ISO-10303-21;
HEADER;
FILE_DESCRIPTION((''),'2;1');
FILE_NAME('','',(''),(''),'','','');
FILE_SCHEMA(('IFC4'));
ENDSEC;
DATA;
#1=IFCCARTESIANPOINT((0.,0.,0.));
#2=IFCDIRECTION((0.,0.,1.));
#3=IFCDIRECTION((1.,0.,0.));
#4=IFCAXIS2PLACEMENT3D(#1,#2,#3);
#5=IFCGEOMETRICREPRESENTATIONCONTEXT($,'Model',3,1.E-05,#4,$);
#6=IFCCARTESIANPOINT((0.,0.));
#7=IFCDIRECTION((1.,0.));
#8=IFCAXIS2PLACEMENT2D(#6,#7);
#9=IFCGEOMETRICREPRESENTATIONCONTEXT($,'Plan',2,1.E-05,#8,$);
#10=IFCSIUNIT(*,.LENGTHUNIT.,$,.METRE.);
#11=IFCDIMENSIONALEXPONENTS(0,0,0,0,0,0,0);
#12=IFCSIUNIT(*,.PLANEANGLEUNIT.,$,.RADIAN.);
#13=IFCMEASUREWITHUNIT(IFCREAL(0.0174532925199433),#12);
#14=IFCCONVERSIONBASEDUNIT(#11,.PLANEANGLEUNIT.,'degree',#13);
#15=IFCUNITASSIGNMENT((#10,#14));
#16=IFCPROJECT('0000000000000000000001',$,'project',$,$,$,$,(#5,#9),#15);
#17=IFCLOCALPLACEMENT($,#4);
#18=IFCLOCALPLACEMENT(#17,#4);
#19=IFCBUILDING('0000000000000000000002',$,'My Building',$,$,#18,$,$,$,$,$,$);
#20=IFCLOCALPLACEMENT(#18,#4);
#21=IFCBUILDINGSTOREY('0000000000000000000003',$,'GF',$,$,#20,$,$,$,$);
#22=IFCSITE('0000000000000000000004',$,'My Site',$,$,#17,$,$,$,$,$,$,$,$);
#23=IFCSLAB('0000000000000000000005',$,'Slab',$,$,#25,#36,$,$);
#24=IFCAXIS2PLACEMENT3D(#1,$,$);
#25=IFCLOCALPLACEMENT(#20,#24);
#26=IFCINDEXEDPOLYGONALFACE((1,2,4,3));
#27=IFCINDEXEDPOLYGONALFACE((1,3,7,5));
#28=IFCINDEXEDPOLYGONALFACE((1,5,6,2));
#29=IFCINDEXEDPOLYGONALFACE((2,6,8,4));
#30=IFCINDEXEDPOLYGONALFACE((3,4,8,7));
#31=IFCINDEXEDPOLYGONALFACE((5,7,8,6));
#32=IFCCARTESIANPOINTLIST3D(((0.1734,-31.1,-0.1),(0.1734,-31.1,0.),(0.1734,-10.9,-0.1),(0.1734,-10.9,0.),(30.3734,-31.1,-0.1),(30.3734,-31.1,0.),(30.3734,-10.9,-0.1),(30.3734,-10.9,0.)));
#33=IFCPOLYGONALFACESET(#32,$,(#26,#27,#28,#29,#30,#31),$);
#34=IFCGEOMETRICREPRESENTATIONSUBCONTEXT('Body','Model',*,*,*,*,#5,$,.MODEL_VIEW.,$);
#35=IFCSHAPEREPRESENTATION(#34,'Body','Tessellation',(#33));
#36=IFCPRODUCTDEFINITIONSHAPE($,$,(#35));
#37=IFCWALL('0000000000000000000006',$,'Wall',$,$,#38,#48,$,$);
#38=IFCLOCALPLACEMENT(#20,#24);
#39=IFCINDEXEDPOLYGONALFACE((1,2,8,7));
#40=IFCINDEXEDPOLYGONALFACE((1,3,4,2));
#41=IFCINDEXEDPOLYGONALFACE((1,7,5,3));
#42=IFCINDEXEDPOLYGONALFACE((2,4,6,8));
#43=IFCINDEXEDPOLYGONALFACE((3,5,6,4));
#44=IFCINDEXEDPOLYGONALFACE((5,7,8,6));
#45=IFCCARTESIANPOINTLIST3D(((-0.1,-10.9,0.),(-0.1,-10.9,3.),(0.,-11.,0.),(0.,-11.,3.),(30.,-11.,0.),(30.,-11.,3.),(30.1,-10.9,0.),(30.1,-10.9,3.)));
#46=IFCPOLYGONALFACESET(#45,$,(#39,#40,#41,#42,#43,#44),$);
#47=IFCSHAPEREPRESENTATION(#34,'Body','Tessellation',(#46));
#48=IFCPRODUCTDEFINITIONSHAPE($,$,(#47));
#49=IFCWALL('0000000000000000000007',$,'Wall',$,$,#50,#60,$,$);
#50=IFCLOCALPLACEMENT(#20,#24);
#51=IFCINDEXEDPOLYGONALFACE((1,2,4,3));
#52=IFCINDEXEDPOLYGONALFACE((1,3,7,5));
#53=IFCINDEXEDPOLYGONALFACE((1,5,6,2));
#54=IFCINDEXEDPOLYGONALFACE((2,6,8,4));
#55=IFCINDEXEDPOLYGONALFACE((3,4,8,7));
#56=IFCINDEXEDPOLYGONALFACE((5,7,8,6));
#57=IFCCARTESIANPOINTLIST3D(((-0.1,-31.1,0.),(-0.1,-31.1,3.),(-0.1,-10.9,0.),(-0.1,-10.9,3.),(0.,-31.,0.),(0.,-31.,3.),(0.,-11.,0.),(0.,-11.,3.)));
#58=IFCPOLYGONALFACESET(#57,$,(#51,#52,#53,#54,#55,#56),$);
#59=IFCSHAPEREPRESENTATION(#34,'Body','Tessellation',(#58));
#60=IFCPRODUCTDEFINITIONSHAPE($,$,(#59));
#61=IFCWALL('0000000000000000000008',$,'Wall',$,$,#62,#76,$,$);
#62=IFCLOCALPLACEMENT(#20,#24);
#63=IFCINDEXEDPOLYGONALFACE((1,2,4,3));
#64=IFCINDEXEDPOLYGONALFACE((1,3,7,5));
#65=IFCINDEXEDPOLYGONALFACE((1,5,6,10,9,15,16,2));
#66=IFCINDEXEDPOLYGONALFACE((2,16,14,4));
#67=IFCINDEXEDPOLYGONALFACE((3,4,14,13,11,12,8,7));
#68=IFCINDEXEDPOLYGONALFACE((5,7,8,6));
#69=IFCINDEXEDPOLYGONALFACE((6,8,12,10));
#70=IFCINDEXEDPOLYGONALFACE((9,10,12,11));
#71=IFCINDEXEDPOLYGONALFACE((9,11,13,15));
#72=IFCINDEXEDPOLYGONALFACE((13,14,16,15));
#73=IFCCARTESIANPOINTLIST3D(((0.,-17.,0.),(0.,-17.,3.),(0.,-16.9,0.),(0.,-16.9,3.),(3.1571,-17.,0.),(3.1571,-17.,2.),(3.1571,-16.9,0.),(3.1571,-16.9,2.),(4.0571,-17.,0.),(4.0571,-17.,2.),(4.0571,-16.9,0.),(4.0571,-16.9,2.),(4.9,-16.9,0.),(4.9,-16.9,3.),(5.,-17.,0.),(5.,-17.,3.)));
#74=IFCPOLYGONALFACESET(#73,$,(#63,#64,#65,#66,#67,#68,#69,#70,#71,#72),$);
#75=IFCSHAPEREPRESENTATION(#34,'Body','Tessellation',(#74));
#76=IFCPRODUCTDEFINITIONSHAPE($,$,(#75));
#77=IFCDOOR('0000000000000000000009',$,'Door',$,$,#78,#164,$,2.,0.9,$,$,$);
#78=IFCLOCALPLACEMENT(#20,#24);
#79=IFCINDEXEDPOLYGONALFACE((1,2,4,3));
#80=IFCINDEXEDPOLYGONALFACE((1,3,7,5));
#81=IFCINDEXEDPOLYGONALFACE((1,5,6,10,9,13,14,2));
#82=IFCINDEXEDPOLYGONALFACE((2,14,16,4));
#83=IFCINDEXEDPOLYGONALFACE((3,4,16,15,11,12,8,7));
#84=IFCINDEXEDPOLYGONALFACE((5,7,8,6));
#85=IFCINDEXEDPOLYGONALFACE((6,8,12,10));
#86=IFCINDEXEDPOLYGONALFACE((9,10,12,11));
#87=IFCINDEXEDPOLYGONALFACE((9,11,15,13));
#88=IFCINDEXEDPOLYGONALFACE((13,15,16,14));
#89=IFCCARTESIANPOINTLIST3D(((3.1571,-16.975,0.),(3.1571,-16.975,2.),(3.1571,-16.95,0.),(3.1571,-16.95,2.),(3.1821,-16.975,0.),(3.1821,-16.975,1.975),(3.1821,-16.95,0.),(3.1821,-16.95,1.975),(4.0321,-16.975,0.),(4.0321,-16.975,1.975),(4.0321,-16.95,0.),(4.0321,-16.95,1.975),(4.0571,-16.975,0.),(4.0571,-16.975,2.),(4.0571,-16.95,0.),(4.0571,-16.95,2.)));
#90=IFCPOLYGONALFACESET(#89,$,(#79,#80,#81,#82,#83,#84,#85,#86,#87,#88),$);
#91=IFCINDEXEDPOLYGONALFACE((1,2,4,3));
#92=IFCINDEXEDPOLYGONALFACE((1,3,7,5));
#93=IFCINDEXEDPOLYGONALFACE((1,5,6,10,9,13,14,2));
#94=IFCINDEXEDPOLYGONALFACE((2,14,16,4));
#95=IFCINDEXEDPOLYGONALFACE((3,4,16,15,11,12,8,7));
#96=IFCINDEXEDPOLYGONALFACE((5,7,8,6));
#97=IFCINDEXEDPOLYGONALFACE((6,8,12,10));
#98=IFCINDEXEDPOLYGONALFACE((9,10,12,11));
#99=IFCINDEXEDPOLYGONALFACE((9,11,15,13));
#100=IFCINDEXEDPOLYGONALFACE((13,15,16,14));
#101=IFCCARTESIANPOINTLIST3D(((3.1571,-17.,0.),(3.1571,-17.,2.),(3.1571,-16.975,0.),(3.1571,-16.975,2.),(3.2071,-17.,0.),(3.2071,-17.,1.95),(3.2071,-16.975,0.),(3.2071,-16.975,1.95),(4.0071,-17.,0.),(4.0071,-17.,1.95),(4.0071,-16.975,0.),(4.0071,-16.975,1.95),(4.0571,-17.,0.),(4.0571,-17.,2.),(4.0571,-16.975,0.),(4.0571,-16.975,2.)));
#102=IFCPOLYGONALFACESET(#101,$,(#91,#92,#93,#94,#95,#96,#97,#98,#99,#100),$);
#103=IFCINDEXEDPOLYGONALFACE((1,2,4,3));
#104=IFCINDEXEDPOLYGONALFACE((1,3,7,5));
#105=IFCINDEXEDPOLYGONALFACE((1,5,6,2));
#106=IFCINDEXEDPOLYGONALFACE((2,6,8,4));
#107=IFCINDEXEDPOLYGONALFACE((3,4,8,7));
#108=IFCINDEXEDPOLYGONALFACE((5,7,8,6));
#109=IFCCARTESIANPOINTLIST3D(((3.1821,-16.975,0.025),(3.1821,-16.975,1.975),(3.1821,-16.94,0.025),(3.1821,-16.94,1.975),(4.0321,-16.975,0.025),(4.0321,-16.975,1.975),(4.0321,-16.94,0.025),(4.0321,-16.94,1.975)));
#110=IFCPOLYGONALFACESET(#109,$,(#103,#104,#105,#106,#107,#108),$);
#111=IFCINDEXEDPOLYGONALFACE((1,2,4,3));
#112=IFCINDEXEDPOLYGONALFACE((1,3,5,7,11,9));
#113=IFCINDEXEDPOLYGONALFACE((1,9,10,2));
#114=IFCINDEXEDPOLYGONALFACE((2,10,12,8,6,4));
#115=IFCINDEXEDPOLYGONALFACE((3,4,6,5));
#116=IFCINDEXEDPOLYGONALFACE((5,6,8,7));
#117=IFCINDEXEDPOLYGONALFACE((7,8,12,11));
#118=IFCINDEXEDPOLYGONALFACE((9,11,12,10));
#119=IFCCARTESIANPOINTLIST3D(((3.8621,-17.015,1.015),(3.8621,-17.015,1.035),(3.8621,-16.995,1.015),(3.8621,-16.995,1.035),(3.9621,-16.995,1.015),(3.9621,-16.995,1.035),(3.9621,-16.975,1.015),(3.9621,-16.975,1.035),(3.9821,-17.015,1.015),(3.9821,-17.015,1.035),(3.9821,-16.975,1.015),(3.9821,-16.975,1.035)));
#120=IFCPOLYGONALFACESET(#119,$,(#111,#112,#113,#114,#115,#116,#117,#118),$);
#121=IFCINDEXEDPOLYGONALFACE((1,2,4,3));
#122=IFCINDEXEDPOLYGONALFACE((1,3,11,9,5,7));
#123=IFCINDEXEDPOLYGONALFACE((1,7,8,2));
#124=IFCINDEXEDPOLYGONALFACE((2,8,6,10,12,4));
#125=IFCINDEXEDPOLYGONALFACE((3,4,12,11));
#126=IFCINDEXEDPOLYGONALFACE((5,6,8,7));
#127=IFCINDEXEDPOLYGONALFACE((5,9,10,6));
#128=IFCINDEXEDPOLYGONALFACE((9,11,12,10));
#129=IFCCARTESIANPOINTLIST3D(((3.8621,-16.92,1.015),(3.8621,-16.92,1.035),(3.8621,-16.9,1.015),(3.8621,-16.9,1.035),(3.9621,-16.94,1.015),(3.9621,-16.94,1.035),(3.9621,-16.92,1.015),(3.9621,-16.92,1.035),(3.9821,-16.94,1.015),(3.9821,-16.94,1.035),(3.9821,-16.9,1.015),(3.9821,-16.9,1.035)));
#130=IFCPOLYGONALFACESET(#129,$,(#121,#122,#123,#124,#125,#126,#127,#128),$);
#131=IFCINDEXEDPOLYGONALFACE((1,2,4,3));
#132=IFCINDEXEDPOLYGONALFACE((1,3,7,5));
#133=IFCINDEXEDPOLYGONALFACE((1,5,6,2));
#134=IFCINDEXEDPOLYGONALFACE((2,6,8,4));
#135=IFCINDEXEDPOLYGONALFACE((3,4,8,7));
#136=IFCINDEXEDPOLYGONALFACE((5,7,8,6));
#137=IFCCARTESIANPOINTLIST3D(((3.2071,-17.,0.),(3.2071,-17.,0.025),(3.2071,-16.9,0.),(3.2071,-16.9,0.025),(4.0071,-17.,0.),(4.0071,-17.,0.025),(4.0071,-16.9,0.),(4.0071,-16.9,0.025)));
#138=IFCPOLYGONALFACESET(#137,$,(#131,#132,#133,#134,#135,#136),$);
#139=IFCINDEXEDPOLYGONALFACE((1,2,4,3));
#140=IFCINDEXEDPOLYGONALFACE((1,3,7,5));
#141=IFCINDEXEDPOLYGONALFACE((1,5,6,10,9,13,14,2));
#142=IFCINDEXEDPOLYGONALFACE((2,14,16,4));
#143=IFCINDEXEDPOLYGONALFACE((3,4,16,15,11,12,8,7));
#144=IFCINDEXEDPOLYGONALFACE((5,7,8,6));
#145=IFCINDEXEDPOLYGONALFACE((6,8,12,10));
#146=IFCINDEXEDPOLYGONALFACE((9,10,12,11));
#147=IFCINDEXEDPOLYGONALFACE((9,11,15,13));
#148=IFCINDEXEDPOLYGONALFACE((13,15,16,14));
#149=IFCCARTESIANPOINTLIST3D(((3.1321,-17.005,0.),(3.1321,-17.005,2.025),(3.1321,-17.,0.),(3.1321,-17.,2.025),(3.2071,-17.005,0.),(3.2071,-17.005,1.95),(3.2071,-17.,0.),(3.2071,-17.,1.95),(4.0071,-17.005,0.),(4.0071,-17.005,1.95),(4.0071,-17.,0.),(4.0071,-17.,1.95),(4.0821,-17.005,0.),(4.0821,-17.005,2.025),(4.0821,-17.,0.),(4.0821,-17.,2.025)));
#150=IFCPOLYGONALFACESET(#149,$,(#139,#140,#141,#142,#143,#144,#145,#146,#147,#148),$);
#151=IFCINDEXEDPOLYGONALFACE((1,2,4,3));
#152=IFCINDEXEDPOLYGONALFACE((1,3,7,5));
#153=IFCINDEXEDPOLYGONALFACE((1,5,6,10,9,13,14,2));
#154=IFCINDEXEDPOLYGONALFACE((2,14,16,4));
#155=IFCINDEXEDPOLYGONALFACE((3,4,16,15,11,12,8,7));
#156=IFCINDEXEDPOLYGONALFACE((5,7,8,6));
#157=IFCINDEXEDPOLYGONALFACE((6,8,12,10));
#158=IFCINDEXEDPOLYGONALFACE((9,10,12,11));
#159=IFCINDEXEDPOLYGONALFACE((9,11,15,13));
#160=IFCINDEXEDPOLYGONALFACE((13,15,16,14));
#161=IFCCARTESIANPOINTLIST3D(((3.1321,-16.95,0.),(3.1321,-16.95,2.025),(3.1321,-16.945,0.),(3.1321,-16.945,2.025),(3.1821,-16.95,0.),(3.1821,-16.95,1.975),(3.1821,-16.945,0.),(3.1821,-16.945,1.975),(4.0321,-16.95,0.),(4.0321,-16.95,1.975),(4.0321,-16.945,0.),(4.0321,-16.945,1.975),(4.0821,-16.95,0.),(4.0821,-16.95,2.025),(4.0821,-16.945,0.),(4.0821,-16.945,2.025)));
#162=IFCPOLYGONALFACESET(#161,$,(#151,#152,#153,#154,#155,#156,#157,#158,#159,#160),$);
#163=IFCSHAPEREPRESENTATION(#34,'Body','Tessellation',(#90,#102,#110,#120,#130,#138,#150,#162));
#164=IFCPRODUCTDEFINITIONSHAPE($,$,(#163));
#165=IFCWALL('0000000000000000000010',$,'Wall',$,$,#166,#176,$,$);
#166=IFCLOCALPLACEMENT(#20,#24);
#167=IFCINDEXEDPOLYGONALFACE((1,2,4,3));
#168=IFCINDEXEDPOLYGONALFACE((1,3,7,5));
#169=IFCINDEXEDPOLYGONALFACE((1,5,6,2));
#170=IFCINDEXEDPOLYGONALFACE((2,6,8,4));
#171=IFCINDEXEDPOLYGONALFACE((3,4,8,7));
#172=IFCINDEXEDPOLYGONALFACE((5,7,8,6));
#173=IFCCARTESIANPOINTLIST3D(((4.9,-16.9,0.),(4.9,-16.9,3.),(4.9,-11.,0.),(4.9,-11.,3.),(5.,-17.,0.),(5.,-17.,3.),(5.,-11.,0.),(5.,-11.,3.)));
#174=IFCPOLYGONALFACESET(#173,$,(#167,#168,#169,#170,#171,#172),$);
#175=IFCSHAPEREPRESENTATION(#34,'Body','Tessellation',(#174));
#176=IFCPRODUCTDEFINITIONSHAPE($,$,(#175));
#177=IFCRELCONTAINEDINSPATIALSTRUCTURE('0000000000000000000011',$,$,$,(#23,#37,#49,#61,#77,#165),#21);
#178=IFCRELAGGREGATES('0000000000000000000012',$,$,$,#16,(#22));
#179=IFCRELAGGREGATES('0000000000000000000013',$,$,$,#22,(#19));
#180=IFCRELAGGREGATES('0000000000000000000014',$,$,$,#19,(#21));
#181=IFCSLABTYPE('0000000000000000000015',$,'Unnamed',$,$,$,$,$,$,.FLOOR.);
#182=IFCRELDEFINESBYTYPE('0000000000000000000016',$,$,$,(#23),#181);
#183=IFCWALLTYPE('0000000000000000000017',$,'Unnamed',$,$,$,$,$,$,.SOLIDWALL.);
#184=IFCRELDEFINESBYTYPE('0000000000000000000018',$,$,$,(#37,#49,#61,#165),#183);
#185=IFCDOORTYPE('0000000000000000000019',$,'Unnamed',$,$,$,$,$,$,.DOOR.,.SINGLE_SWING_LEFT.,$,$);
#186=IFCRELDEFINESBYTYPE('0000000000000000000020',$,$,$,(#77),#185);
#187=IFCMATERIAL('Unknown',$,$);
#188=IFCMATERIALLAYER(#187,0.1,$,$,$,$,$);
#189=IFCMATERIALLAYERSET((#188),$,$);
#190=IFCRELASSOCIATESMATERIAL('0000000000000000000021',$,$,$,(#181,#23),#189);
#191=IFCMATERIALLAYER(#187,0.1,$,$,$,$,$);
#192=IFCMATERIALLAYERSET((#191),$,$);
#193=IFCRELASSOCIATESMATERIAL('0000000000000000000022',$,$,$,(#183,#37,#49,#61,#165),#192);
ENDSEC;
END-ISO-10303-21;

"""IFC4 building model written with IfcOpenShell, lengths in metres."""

from ifc_helpers import new_model, entity, si_unit, converted_unit, frame, origin_with_axes, origin_2d_with_axis, place, context, subcontext, project, spatial, line, indexed_curve, outline, extrude, shape, source, transform, mapped, material, layer, layer_set, layer_usage, type_object, type_shapes, element, fill, save


model = new_model("IFC4")

# Units and contexts
model_context = context("Model", 3, precision=1e-05, world=origin_with_axes())
plan_context = context("Plan", 2, precision=1e-05, world=origin_2d_with_axis())
body_context_1 = subcontext(model_context, "Body", "Model", "MODEL_VIEW")
body_context_2 = subcontext(plan_context, "Body", "Plan", "PLAN_VIEW")
ifc_project = project(units=[si_unit("LENGTHUNIT", "METRE"), converted_unit("PLANEANGLEUNIT", "degree", entity("IfcReal", 0.0174532925199433), si_unit("PLANEANGLEUNIT", "RADIAN"), dimensions=[0, 0, 0, 0, 0, 0, 0])], contexts=[model_context, plan_context])

# Site, building, storey
site_placement = place(None, origin_with_axes())
site = spatial("IfcSite", under=ifc_project, at=site_placement, Name="My Site")
building_placement = place(site_placement, origin_with_axes())
building = spatial("IfcBuilding", under=site, at=building_placement, Name="My Building")
storey_placement = place(building_placement, origin_with_axes())
storey = spatial("IfcBuildingStorey", under=building, at=storey_placement, Name="GF")

# Slab
ifc_material = material(Name="Unknown")
ifc_layer_1 = layer(ifc_material, 0.1)
ifc_layer_set_1 = layer_set([ifc_layer_1])
ifc_layer_usage_1 = layer_usage(ifc_layer_set_1, "AXIS3", "POSITIVE", -0.1)
slab_type = type_object("IfcSlabType", Name="Unnamed", PredefinedType="FLOOR", material=ifc_layer_set_1)
slab_placement = place(storey_placement, frame((0.1734, -10.9, 0.0), z_axis=(0.0, 0.0, 1.0), x_axis=(1.0, 0.0, 0.0)))
element("IfcSlab", 1, at=slab_placement, inside=storey, type_object=slab_type, material=ifc_layer_usage_1, Name="Slab", context=body_context_1, shape_type="SweptSolid", body=[
    extrude(outline(indexed_curve([(0.0, 0.0), (30.2, 0.0), (30.2, -20.2), (0.0, -20.2), (0.0, 0.0)])), frame((0.0, 0.0, -0.1), z_axis=(0.0, 0.0, 1.0), x_axis=(1.0, 0.0, 0.0)), (0.0, 0.0, 1.0), 0.1),
])

# Walls
ifc_layer_2 = layer(ifc_material, 0.1)
ifc_layer_set_2 = layer_set([ifc_layer_2])
ifc_layer_usage_2 = layer_usage(ifc_layer_set_2, "AXIS2", "POSITIVE", 0.0)
wall_type = type_object("IfcWallType", Name="Unnamed", PredefinedType="SOLIDWALL", material=ifc_layer_set_2)
wall_1_placement = place(storey_placement, frame((0.0, -11.0, 0.0), z_axis=(0.0, 0.0, 1.0), x_axis=(1.0, 0.0, 0.0)))
element("IfcWall", 2, at=wall_1_placement, inside=storey, type_object=wall_type, material=ifc_layer_usage_2, Name="Wall", context=body_context_1, shape_type="SweptSolid", body=[
    extrude(outline(indexed_curve([(0.0, 0.0), (-0.1, 0.1), (30.1, 0.1), (30.0, 0.0)], segments=[line(1, 2, 3, 4, 1)])), origin_with_axes(), (0.0, 0.0, 1.0), 3.0),
])
ifc_layer_usage_3 = layer_usage(ifc_layer_set_2, "AXIS2", "POSITIVE", 0.0)
wall_2_placement = place(storey_placement, frame((0.0, -31.0, 0.0), z_axis=(0.0, 0.0, 1.0), x_axis=(0.0, 1.0, 0.0)))
element("IfcWall", 3, at=wall_2_placement, inside=storey, type_object=wall_type, material=ifc_layer_usage_3, Name="Wall", context=body_context_1, shape_type="SweptSolid", body=[
    extrude(outline(indexed_curve([(0.0, 0.0), (-0.1, 0.1), (20.1, 0.1), (20.0, 0.0)], segments=[line(1, 2, 3, 4, 1)])), origin_with_axes(), (0.0, 0.0, 1.0), 3.0),
])

# Wall, opening, door
ifc_layer_usage_4 = layer_usage(ifc_layer_set_2, "AXIS2", "POSITIVE", 0.0)
wall_3_placement = place(storey_placement, frame((0.0, -17.0, 0.0), z_axis=(0.0, 0.0, 1.0), x_axis=(1.0, 0.0, 0.0)))
wall_3 = element("IfcWall", 4, at=wall_3_placement, inside=storey, type_object=wall_type, material=ifc_layer_usage_4, Name="Wall", context=body_context_1, shape_type="SweptSolid", body=[
    extrude(outline(indexed_curve([(0.0, 0.0), (0.0, 0.1), (4.9, 0.1), (5.0, 0.0)], segments=[line(1, 2, 3, 4, 1)])), origin_with_axes(), (0.0, 0.0, 1.0), 3.0),
])
shared_shape_1 = source(origin_with_axes(), body_context_1, "Body", "SweptSolid", [
    extrude(outline(indexed_curve([(0.0, 0.0), (0.9, 0.0), (0.9, 2.0), (0.0, 2.0)], segments=[line(1, 2, 3, 4, 1)])), frame((0.0, -0.6, 0.0), z_axis=(0.0, -1.0, 0.0), x_axis=(1.0, 0.0, 0.0)), (0.0, 0.0, -1.0), 1.2),
])
opening_1_placement = place(wall_3_placement, frame((3.1571, 0.0, 0.0), z_axis=(0.0, 0.0, 1.0), x_axis=(1.0, 0.0, 0.0)))
opening_1 = element("IfcOpeningElement", 5, at=opening_1_placement, cuts=wall_3, PredefinedType="OPENING", context=body_context_1, shape_type="MappedRepresentation", body=[
    mapped(shared_shape_1, transform((0.0, 0.0, 0.0), x_axis=(1.0, 0.0, 0.0), y_axis=(0.0, 1.0, 0.0), z_axis=(0.0, 0.0, 1.0), scale=1.0)),
])
door_type = type_object("IfcDoorType", Name="Unnamed", OperationType="SINGLE_SWING_LEFT", PredefinedType="DOOR")
shared_shape_2 = source(origin_with_axes(), body_context_1, "Body", "SweptSolid", [
    extrude(outline(indexed_curve([(0.0, 0.0), (0.0, 2.0), (0.9, 2.0), (0.9, 0.0), (0.875, 0.0), (0.875, 1.975), (0.025, 1.975), (0.025, 0.0)], segments=[line(1, 2, 3, 4, 5, 6, 7, 8, 1)])), frame((0.0, 0.025, 0.0), z_axis=(0.0, -1.0, 0.0), x_axis=(1.0, 0.0, 0.0)), (0.0, 0.0, -1.0), 0.025),
    extrude(outline(indexed_curve([(0.0, 0.0), (0.0, 2.0), (0.9, 2.0), (0.9, 0.0), (0.85, 0.0), (0.85, 1.95), (0.05, 1.95), (0.05, 0.0)], segments=[line(1, 2, 3, 4, 5, 6, 7, 8, 1)])), frame((0.0, 0.0, 0.0), z_axis=(0.0, -1.0, 0.0), x_axis=(1.0, 0.0, 0.0)), (0.0, 0.0, -1.0), 0.025),
    extrude(outline(indexed_curve([(0.0, 0.0), (0.85, 0.0), (0.85, 0.035), (0.0, 0.035)], segments=[line(1, 2, 3, 4, 1)])), frame((0.025, 0.025, 0.025), z_axis=(0.0, 0.0, 1.0), x_axis=(1.0, 0.0, 0.0)), (0.0, 0.0, 1.0), 1.95),
    extrude(outline(indexed_curve([(0.0, 0.0), (0.0, -0.04), (-0.12, -0.04), (-0.12, -0.02), (-0.02, -0.02), (-0.02, 0.0)], segments=[line(1, 2, 3, 4, 5, 6, 1)])), frame((0.825, 0.025, 1.015), z_axis=(0.0, 0.0, 1.0), x_axis=(1.0, 0.0, 0.0)), (0.0, 0.0, 1.0), 0.02),
    extrude(outline(indexed_curve([(0.0, 0.0), (0.0, 0.04), (-0.12, 0.04), (-0.12, 0.02), (-0.02, 0.02), (-0.02, 0.0)], segments=[line(1, 2, 3, 4, 5, 6, 1)])), frame((0.825, 0.06, 1.015), z_axis=(0.0, 0.0, 1.0), x_axis=(1.0, 0.0, 0.0)), (0.0, 0.0, 1.0), 0.02),
    extrude(outline(indexed_curve([(0.0, 0.0), (0.8, 0.0), (0.8, 0.1), (0.0, 0.1)], segments=[line(1, 2, 3, 4, 1)])), frame((0.05, 0.0, 0.0), z_axis=(0.0, 0.0, 1.0), x_axis=(1.0, 0.0, 0.0)), (0.0, 0.0, 1.0), 0.025),
    extrude(outline(indexed_curve([(0.0, 0.0), (0.0, 2.025), (0.95, 2.025), (0.95, 0.0), (0.875, 0.0), (0.875, 1.95), (0.075, 1.95), (0.075, 0.0)], segments=[line(1, 2, 3, 4, 5, 6, 7, 8, 1)])), frame((-0.025, -0.005, 0.0), z_axis=(0.0, -1.0, 0.0), x_axis=(1.0, 0.0, 0.0)), (0.0, 0.0, -1.0), 0.005),
    extrude(outline(indexed_curve([(0.0, 0.0), (0.0, 2.025), (0.95, 2.025), (0.95, 0.0), (0.9, 0.0), (0.9, 1.975), (0.05, 1.975), (0.05, 0.0)], segments=[line(1, 2, 3, 4, 5, 6, 7, 8, 1)])), frame((-0.025, 0.05, 0.0), z_axis=(0.0, -1.0, 0.0), x_axis=(1.0, 0.0, 0.0)), (0.0, 0.0, -1.0), 0.005),
])
shared_shape_3 = source(origin_with_axes(), body_context_2, "Body", "Curve2D", [
    entity("IfcIndexedPolyCurve", entity("IfcCartesianPointList2D", [[0.0, 0.0], [0.0, 0.05], [0.025, 0.05], [0.025, 0.025], [0.05, 0.025], [0.05, 0.0]]), [entity("IfcLineIndex", [1, 2, 3, 4, 5, 6, 1])]),
    entity("IfcIndexedPolyCurve", entity("IfcCartesianPointList2D", [[0.9, 0.0], [0.9, 0.05], [0.875, 0.05], [0.875, 0.025], [0.85, 0.025], [0.85, 0.0]]), [entity("IfcLineIndex", [1, 2, 3, 4, 5, 6, 1])]),
    entity("IfcTrimmedCurve", entity("IfcEllipse", entity("IfcAxis2Placement2D", entity("IfcCartesianPoint", [0.06, 0.05]), entity("IfcDirection", [1.0, 0.0])), 0.815, 0.85), [entity("IfcCartesianPoint", [0.875, 0.05])], [entity("IfcCartesianPoint", [0.06, 0.9])], True, "CARTESIAN"),
    entity("IfcIndexedPolyCurve", entity("IfcCartesianPointList2D", [[0.025, 0.05], [0.06, 0.05], [0.06, 0.9], [0.025, 0.9]]), [entity("IfcLineIndex", [1, 2, 3, 4, 1])]),
])
type_shapes(door_type, [shared_shape_2, shared_shape_3])
door_1_placement = place(opening_1_placement, origin_with_axes())
door_1 = element("IfcDoor", 6, at=door_1_placement, inside=storey, type_object=door_type, Name="Door", OverallHeight=2.0, OverallWidth=0.9, shapes=[
    shape(body_context_1, "Body", "MappedRepresentation", [mapped(shared_shape_2, transform((0.0, 0.0, 0.0), x_axis=(1.0, 0.0, 0.0), y_axis=(0.0, 1.0, 0.0), z_axis=(0.0, 0.0, 1.0), scale=1.0))]),
    shape(body_context_2, "Body", "MappedRepresentation", [mapped(shared_shape_3, transform((0.0, 0.0, 0.0), x_axis=(1.0, 0.0, 0.0), y_axis=(0.0, 1.0, 0.0), z_axis=(0.0, 0.0, 1.0), scale=1.0))]),
])
fill(opening_1, door_1)

# Wall
ifc_layer_usage_5 = layer_usage(ifc_layer_set_2, "AXIS2", "POSITIVE", 0.0)
wall_4_placement = place(storey_placement, frame((5.0, -17.0, 0.0), z_axis=(0.0, 0.0, 1.0), x_axis=(0.0, 1.0, 0.0)))
element("IfcWall", 7, at=wall_4_placement, inside=storey, type_object=wall_type, material=ifc_layer_usage_5, Name="Wall", context=body_context_1, shape_type="SweptSolid", body=[
    extrude(outline(indexed_curve([(0.0, 0.0), (0.1, 0.1), (6.0, 0.1), (6.0, 0.0)], segments=[line(1, 2, 3, 4, 1)])), origin_with_axes(), (0.0, 0.0, 1.0), 3.0),
])

save(model, "model.ifc")
